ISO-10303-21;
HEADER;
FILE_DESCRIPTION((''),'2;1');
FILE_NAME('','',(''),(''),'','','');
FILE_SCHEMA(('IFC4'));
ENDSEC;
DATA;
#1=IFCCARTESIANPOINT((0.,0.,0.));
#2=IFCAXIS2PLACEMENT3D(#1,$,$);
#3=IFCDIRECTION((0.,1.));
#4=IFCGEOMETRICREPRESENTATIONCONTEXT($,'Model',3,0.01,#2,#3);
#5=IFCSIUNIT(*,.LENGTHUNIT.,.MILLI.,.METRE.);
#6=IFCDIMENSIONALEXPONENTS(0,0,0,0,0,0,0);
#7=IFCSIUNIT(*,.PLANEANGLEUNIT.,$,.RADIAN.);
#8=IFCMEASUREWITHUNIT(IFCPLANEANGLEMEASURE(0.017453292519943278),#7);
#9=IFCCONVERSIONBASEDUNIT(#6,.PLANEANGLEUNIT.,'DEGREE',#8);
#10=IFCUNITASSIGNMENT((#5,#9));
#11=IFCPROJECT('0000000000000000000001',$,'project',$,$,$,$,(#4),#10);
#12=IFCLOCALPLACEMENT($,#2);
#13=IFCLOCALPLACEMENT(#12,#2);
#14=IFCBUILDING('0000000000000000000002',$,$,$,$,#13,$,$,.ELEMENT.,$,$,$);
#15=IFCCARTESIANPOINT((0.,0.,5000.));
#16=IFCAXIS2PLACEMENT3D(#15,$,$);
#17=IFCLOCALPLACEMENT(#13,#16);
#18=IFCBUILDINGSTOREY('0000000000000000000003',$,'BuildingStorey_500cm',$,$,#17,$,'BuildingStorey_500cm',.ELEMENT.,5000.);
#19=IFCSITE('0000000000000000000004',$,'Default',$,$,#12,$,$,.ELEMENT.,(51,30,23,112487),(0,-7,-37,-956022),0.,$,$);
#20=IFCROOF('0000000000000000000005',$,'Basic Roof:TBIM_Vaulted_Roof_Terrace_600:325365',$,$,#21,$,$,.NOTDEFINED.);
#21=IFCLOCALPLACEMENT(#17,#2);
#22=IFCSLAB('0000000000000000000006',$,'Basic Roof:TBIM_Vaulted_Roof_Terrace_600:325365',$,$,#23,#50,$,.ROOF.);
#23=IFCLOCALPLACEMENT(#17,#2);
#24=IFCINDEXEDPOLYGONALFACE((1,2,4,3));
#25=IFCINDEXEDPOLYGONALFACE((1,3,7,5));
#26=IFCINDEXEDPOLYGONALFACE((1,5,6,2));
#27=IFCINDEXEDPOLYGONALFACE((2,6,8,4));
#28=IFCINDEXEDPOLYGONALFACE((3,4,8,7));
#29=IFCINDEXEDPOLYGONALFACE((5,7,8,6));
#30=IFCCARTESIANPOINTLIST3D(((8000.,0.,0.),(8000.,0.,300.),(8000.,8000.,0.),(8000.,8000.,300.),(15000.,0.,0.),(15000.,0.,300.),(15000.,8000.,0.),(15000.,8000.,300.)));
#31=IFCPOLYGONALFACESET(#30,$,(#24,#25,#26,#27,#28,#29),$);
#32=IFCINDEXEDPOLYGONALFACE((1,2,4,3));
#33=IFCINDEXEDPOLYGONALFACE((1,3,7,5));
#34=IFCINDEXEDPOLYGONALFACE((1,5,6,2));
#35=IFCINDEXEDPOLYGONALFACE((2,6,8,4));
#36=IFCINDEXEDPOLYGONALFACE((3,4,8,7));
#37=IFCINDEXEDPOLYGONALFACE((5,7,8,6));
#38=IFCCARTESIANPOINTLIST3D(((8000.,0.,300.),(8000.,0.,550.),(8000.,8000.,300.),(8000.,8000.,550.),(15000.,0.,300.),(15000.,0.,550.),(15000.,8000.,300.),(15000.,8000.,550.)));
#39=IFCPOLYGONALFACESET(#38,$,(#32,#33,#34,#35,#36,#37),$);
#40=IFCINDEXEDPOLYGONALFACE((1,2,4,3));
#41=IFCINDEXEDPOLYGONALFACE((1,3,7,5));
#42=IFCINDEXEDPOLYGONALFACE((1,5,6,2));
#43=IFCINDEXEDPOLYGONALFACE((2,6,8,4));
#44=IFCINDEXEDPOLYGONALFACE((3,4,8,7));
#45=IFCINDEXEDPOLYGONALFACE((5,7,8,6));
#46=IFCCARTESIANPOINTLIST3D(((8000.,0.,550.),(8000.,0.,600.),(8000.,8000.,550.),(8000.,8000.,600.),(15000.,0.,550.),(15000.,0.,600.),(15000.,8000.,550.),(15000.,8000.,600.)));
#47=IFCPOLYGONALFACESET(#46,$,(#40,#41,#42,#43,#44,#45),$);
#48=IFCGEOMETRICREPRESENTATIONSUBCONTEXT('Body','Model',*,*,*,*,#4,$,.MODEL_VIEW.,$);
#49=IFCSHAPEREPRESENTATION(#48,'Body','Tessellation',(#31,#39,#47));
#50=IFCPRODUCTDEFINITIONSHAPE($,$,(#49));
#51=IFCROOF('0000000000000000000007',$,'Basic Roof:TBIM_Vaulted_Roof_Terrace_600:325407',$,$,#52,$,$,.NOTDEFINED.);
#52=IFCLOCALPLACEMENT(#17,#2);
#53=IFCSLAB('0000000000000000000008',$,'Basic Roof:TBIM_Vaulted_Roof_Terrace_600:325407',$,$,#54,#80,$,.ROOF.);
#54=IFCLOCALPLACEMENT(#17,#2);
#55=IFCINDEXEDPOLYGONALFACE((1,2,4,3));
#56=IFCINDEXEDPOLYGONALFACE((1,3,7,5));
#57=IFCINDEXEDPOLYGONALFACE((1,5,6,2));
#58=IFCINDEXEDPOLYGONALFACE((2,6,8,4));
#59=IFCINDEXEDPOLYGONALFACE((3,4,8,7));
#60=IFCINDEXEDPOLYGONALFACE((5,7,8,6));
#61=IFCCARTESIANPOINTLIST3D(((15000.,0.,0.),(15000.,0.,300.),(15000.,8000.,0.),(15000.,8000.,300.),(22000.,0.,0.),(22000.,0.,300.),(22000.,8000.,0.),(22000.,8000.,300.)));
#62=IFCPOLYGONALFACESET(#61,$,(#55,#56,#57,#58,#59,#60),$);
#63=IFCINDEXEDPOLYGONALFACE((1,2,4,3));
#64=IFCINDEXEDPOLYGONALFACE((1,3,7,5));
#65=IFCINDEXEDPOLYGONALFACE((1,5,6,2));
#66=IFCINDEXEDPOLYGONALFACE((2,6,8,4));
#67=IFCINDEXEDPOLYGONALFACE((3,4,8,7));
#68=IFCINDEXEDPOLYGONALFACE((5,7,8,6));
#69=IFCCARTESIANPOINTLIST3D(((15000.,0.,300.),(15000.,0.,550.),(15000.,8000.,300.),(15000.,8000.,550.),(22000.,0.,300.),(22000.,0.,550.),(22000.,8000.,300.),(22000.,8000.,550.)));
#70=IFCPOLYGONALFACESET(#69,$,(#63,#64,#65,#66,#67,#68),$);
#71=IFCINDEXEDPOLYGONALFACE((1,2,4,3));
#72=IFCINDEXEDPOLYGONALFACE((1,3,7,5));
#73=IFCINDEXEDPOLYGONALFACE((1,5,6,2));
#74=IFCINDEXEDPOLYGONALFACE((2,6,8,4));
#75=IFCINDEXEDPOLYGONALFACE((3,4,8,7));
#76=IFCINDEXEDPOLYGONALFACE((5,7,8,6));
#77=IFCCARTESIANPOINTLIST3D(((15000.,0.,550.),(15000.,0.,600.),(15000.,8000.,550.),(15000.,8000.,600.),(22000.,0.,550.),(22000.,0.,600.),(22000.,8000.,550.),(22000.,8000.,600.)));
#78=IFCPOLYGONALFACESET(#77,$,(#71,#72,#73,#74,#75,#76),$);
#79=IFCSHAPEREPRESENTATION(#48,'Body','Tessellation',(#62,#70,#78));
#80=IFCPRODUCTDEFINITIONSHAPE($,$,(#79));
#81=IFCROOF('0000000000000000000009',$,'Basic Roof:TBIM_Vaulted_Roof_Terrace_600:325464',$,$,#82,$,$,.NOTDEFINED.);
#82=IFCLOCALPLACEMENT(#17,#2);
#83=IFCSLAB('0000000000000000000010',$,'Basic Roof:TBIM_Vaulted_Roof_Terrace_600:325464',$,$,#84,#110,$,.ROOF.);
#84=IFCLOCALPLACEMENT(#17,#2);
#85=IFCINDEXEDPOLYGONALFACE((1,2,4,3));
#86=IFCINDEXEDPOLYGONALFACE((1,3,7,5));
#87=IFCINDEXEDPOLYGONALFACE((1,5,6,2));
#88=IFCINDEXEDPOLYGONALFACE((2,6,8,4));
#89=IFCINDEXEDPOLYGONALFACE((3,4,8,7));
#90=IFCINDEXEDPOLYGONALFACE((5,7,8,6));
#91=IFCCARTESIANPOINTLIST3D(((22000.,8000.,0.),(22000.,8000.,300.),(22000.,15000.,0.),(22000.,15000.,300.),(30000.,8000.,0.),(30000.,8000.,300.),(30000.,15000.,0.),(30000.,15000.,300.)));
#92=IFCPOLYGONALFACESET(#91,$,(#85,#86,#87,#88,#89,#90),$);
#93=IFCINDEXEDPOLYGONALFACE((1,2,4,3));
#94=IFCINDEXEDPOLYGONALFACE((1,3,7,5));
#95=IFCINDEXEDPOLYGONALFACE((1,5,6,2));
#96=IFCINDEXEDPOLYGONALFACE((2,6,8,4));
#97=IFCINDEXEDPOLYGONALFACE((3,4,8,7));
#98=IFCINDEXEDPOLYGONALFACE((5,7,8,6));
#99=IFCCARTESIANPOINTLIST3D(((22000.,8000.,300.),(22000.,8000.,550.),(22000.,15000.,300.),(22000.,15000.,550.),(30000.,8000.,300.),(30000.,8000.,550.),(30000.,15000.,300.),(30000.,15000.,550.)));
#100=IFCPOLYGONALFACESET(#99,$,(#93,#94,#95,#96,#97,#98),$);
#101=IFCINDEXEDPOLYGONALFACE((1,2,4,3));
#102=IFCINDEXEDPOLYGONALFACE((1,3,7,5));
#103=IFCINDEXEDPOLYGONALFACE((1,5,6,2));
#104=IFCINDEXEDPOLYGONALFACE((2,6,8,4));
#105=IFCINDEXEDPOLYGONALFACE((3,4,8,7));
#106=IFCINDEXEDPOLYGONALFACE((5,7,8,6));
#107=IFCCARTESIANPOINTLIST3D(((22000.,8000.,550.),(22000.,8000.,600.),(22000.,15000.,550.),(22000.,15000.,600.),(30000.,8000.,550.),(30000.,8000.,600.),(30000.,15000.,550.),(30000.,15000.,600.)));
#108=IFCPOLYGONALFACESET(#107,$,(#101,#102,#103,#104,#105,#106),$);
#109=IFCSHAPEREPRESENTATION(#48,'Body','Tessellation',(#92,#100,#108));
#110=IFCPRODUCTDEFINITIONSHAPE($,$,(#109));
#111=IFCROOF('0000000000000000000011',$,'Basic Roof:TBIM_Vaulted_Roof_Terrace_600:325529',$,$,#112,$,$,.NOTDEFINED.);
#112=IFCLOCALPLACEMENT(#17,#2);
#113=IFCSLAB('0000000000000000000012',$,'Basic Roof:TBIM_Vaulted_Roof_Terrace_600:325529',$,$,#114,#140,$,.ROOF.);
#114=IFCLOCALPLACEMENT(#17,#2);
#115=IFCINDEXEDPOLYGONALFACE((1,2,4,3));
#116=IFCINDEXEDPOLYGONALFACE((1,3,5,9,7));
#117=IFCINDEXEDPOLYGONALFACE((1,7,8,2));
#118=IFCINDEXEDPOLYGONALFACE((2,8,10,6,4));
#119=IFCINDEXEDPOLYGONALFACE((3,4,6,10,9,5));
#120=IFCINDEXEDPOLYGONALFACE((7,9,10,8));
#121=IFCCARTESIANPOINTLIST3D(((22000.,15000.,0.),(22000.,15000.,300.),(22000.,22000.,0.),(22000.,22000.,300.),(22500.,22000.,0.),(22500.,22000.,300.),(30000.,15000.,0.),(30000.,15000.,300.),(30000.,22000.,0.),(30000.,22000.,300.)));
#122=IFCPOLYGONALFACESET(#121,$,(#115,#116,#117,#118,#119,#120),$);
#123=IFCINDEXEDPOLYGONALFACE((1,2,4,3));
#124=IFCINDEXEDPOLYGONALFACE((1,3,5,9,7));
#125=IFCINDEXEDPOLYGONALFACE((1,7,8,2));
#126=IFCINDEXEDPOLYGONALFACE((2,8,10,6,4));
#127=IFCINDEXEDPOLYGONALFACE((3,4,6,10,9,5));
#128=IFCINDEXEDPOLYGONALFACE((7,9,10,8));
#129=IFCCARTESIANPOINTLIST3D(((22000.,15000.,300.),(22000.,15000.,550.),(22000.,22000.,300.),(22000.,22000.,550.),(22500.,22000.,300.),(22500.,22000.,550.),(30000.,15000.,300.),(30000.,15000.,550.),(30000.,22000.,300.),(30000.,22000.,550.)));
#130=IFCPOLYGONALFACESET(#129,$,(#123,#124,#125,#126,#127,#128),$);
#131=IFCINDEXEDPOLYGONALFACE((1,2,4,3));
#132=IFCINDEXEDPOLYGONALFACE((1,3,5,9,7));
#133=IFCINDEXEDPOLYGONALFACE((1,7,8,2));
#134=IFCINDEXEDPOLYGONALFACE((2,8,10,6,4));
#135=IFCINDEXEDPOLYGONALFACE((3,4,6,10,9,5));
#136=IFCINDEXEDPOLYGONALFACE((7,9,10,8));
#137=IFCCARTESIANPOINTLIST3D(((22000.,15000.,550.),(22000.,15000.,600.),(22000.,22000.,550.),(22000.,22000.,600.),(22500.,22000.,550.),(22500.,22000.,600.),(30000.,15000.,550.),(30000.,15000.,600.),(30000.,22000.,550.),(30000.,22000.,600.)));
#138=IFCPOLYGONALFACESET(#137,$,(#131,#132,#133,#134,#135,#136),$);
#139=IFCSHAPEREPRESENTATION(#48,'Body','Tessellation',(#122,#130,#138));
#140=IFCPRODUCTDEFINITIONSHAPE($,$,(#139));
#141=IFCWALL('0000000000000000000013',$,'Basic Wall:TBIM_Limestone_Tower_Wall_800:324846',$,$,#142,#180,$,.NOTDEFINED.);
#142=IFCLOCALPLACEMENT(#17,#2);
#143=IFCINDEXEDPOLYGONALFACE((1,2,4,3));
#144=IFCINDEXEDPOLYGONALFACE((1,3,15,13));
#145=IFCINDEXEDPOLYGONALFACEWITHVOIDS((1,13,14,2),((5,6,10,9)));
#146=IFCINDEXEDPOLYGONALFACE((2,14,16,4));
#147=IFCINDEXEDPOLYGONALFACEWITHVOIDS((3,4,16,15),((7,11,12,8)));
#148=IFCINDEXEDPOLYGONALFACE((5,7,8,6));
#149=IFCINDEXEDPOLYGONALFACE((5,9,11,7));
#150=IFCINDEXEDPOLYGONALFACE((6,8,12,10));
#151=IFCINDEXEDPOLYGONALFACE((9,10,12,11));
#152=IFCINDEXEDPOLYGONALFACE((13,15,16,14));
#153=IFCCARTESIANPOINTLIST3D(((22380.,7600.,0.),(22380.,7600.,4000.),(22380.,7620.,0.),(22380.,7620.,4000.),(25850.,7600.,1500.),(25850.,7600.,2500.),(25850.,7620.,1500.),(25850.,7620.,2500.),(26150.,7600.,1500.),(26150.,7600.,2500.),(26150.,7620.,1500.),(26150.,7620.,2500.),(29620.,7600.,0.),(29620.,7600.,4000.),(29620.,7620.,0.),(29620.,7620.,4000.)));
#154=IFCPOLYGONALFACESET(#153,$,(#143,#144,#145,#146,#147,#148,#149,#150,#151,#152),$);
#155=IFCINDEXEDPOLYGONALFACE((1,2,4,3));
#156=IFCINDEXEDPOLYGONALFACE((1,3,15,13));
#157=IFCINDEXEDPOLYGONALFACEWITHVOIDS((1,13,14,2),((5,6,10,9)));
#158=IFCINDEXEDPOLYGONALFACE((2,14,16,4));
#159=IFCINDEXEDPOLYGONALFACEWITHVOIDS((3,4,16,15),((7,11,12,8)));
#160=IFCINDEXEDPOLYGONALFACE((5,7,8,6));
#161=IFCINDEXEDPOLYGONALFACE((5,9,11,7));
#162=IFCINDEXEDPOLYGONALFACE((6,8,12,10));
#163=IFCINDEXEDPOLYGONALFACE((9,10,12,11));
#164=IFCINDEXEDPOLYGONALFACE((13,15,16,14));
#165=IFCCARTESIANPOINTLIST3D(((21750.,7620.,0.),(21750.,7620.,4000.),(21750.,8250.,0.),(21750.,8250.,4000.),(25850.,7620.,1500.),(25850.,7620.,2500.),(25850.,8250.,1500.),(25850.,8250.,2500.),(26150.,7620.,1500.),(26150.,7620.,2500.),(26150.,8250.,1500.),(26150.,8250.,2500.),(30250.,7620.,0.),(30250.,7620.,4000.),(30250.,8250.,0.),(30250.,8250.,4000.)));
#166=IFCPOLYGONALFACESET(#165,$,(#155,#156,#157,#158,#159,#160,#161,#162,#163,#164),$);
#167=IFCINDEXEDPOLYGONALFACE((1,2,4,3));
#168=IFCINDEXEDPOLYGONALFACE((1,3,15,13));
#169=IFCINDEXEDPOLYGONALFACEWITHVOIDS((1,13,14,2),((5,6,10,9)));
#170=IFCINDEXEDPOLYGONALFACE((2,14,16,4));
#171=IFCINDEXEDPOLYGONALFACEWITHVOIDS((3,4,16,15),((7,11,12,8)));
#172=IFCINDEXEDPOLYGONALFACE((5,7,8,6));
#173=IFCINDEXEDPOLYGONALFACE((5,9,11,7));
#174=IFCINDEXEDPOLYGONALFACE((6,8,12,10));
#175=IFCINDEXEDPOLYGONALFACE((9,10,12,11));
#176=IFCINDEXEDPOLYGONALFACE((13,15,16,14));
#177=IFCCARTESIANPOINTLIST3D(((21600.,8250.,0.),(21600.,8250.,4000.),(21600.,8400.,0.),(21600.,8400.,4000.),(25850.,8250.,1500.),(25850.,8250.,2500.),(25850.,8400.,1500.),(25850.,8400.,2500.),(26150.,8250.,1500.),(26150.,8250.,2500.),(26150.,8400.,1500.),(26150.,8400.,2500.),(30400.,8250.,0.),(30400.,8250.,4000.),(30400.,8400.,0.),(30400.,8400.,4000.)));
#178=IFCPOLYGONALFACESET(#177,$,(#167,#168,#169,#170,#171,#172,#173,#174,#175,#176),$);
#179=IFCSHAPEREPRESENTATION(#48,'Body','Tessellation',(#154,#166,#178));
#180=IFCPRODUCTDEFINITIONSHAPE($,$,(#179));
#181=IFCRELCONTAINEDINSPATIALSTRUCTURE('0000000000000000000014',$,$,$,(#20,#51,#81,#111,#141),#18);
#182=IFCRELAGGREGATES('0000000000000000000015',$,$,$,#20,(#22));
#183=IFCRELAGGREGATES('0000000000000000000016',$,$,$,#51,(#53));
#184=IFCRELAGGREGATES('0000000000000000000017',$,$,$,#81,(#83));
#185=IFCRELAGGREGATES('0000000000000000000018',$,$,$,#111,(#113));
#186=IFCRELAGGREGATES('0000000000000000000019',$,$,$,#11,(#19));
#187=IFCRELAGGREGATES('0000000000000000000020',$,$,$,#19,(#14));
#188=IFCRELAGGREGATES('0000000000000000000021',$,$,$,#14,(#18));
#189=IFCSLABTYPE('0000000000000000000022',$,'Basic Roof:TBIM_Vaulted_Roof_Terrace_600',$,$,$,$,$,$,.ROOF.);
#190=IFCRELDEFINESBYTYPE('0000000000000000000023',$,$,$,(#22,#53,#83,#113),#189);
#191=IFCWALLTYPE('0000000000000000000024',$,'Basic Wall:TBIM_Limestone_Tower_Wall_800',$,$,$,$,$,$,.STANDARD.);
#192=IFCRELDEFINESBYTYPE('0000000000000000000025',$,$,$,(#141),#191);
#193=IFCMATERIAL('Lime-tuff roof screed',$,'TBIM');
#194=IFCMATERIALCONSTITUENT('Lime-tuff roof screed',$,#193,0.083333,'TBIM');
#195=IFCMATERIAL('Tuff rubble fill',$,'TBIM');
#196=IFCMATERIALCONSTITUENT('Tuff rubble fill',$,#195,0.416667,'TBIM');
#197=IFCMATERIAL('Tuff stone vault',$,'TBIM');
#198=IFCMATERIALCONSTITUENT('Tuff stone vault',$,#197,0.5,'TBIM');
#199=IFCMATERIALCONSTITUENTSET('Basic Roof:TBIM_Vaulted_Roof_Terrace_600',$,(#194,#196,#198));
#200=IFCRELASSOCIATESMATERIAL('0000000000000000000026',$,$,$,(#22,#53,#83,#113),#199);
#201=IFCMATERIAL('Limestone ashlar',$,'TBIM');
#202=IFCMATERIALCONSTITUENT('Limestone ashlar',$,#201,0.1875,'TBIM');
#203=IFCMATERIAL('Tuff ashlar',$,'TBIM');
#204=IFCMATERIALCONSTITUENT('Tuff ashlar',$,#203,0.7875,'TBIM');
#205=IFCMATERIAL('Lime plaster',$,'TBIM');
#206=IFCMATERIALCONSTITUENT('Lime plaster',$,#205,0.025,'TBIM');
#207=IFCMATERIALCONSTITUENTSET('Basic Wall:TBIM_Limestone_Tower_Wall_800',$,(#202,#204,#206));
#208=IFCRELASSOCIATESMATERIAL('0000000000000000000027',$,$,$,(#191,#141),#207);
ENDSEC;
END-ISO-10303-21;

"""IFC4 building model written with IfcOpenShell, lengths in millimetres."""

from ifc_helpers import new_model, entity, si_unit, converted_unit, direction, frame, origin, place, context, subcontext, project, spatial, indexed_curve, outline, extrude, material, constituent, constituent_set, type_object, element, aggregate, save


model = new_model("IFC4")

# Units and contexts
model_context = context("Model", 3, precision=0.01, world=origin(), true_north=direction((0.0, 1.0)))
body_context = subcontext(model_context, "Body", "Model", "MODEL_VIEW")
ifc_project = project(units=[si_unit("LENGTHUNIT", "METRE", prefix="MILLI"), converted_unit("PLANEANGLEUNIT", "DEGREE", entity("IfcPlaneAngleMeasure", 0.017453292519943278), si_unit("PLANEANGLEUNIT", "RADIAN"), dimensions=[0, 0, 0, 0, 0, 0, 0])], contexts=[model_context])

# Site, building, storey
site_placement = place(None, origin())
site = spatial("IfcSite", under=ifc_project, at=site_placement, Name="Default", CompositionType="ELEMENT", RefLatitude=(51, 30, 23, 112487), RefLongitude=(0, -7, -37, -956022), RefElevation=0.0)
building_placement = place(site_placement, origin())
building = spatial("IfcBuilding", under=site, at=building_placement, CompositionType="ELEMENT")
storey_placement = place(building_placement, frame((0.0, 0.0, 5000.0)))
storey = spatial("IfcBuildingStorey", under=building, at=storey_placement, Name="BuildingStorey_500cm", LongName="BuildingStorey_500cm", CompositionType="ELEMENT", Elevation=5000.0)

# Roofs, slabs
roof_1_placement = place(storey_placement, frame((8000.0, 0.0, 0.0)))
roof_1 = element("IfcRoof", 1, at=roof_1_placement, inside=storey, Name="Basic Roof:TBIM_Vaulted_Roof_Terrace_600:325365", PredefinedType="NOTDEFINED")
ifc_material_1 = material(Name="Lime-tuff roof screed", Category="TBIM")
ifc_constituent_1 = constituent(ifc_material_1, Name="Lime-tuff roof screed", Category="TBIM", fraction=0.083333)
ifc_material_2 = material(Name="Tuff rubble fill", Category="TBIM")
ifc_constituent_2 = constituent(ifc_material_2, Name="Tuff rubble fill", Category="TBIM", fraction=0.416667)
ifc_material_3 = material(Name="Tuff stone vault", Category="TBIM")
ifc_constituent_3 = constituent(ifc_material_3, Name="Tuff stone vault", Category="TBIM", fraction=0.5)
ifc_constituent_set_1 = constituent_set(constituents=[ifc_constituent_1, ifc_constituent_2, ifc_constituent_3], Name="Basic Roof:TBIM_Vaulted_Roof_Terrace_600")
slab_type = type_object("IfcSlabType", Name="Basic Roof:TBIM_Vaulted_Roof_Terrace_600", PredefinedType="ROOF")
slab_1_placement = place(roof_1_placement, origin())
slab_1 = element("IfcSlab", 2, at=slab_1_placement, type_object=slab_type, material=ifc_constituent_set_1, Name="Basic Roof:TBIM_Vaulted_Roof_Terrace_600:325365", PredefinedType="ROOF", context=body_context, shape_type="SweptSolid", body=[
    extrude(outline(indexed_curve([(-3500.0, 4000.0), (-3500.0, -4000.0), (3500.0, -4000.0), (3500.0, 4000.0), (-3500.0, 4000.0)], self_intersect=False)), frame((3500.0, 4000.0, 0.0)), (0.0, 0.0, 1.0), 300.0),
    extrude(outline(indexed_curve([(-3500.0, 4000.0), (-3500.0, -4000.0), (3500.0, -4000.0), (3500.0, 4000.0), (-3500.0, 4000.0)], self_intersect=False)), frame((3500.0, 4000.0, 300.0)), (0.0, 0.0, 1.0), 250.0),
    extrude(outline(indexed_curve([(-3500.0, 4000.0), (-3500.0, -4000.0), (3500.0, -4000.0), (3500.0, 4000.0), (-3500.0, 4000.0)], self_intersect=False)), frame((3500.0, 4000.0, 550.0)), (0.0, 0.0, 1.0), 50.0),
])
aggregate(roof_1, [slab_1])
roof_2_placement = place(storey_placement, frame((15000.0, 0.0, 0.0)))
roof_2 = element("IfcRoof", 3, at=roof_2_placement, inside=storey, Name="Basic Roof:TBIM_Vaulted_Roof_Terrace_600:325407", PredefinedType="NOTDEFINED")
slab_2_placement = place(roof_2_placement, origin())
slab_2 = element("IfcSlab", 4, at=slab_2_placement, type_object=slab_type, material=ifc_constituent_set_1, Name="Basic Roof:TBIM_Vaulted_Roof_Terrace_600:325407", PredefinedType="ROOF", context=body_context, shape_type="SweptSolid", body=[
    extrude(outline(indexed_curve([(-3500.0, 4000.0), (-3500.0, -4000.0), (3500.0, -4000.0), (3500.0, 4000.0), (-3500.0, 4000.0)], self_intersect=False)), frame((3500.0, 4000.0, 0.0)), (0.0, 0.0, 1.0), 300.0),
    extrude(outline(indexed_curve([(-3500.0, 4000.0), (-3500.0, -4000.0), (3500.0, -4000.0), (3500.0, 4000.0), (-3500.0, 4000.0)], self_intersect=False)), frame((3500.0, 4000.0, 300.0)), (0.0, 0.0, 1.0), 250.0),
    extrude(outline(indexed_curve([(-3500.0, 4000.0), (-3500.0, -4000.0), (3500.0, -4000.0), (3500.0, 4000.0), (-3500.0, 4000.0)], self_intersect=False)), frame((3500.0, 4000.0, 550.0)), (0.0, 0.0, 1.0), 50.0),
])
aggregate(roof_2, [slab_2])
roof_3_placement = place(storey_placement, frame((22000.0, 8000.0, 0.0)))
roof_3 = element("IfcRoof", 5, at=roof_3_placement, inside=storey, Name="Basic Roof:TBIM_Vaulted_Roof_Terrace_600:325464", PredefinedType="NOTDEFINED")
slab_3_placement = place(roof_3_placement, origin())
slab_3 = element("IfcSlab", 6, at=slab_3_placement, type_object=slab_type, material=ifc_constituent_set_1, Name="Basic Roof:TBIM_Vaulted_Roof_Terrace_600:325464", PredefinedType="ROOF", context=body_context, shape_type="SweptSolid", body=[
    extrude(outline(indexed_curve([(-4000.0, 3500.0), (-4000.0, -3500.0), (4000.0, -3500.0), (4000.0, 3500.0), (-4000.0, 3500.0)], self_intersect=False)), frame((4000.0, 3500.0, 0.0)), (0.0, 0.0, 1.0), 300.0),
    extrude(outline(indexed_curve([(-4000.0, 3500.0), (-4000.0, -3500.0), (4000.0, -3500.0), (4000.0, 3500.0), (-4000.0, 3500.0)], self_intersect=False)), frame((4000.0, 3500.0, 300.0)), (0.0, 0.0, 1.0), 250.0),
    extrude(outline(indexed_curve([(-4000.0, 3500.0), (-4000.0, -3500.0), (4000.0, -3500.0), (4000.0, 3500.0), (-4000.0, 3500.0)], self_intersect=False)), frame((4000.0, 3500.0, 550.0)), (0.0, 0.0, 1.0), 50.0),
])
aggregate(roof_3, [slab_3])
roof_4_placement = place(storey_placement, frame((22000.0, 15000.0, 0.0)))
roof_4 = element("IfcRoof", 7, at=roof_4_placement, inside=storey, Name="Basic Roof:TBIM_Vaulted_Roof_Terrace_600:325529", PredefinedType="NOTDEFINED")
slab_4_placement = place(roof_4_placement, origin())
slab_4 = element("IfcSlab", 8, at=slab_4_placement, type_object=slab_type, material=ifc_constituent_set_1, Name="Basic Roof:TBIM_Vaulted_Roof_Terrace_600:325529", PredefinedType="ROOF", context=body_context, shape_type="SweptSolid", body=[
    extrude(outline(indexed_curve([(4000.0, 3500.0), (-3500.0, 3500.0), (-4000.0, 3500.0), (-4000.0, -3500.0), (4000.0, -3500.0), (4000.0, 3500.0)], self_intersect=False)), frame((4000.0, 3500.0, 0.0)), (0.0, 0.0, 1.0), 300.0),
    extrude(outline(indexed_curve([(4000.0, 3500.0), (-3500.0, 3500.0), (-4000.0, 3500.0), (-4000.0, -3500.0), (4000.0, -3500.0), (4000.0, 3500.0)], self_intersect=False)), frame((4000.0, 3500.0, 300.0)), (0.0, 0.0, 1.0), 250.0),
    extrude(outline(indexed_curve([(4000.0, 3500.0), (-3500.0, 3500.0), (-4000.0, 3500.0), (-4000.0, -3500.0), (4000.0, -3500.0), (4000.0, 3500.0)], self_intersect=False)), frame((4000.0, 3500.0, 550.0)), (0.0, 0.0, 1.0), 50.0),
])
aggregate(roof_4, [slab_4])

# Shared definitions
ifc_material_4 = material(Name="Tuff ashlar", Category="TBIM")
ifc_material_5 = material(Name="Lime plaster", Category="TBIM")

# Wall, opening
ifc_material_6 = material(Name="Limestone ashlar", Category="TBIM")
ifc_constituent_4 = constituent(ifc_material_6, Name="Limestone ashlar", Category="TBIM", fraction=0.1875)
ifc_constituent_5 = constituent(ifc_material_4, Name="Tuff ashlar", Category="TBIM", fraction=0.7875)
ifc_constituent_6 = constituent(ifc_material_5, Name="Lime plaster", Category="TBIM", fraction=0.025)
ifc_constituent_set_2 = constituent_set(constituents=[ifc_constituent_4, ifc_constituent_5, ifc_constituent_6], Name="Basic Wall:TBIM_Limestone_Tower_Wall_800")
wall_type_1 = type_object("IfcWallType", Name="Basic Wall:TBIM_Limestone_Tower_Wall_800", PredefinedType="STANDARD", material=ifc_constituent_set_2)
wall_1_placement = place(storey_placement, frame((21600.0, 8000.0, 0.0)))
wall_1 = element("IfcWall", 9, at=wall_1_placement, inside=storey, type_object=wall_type_1, material=ifc_constituent_set_2, Name="Basic Wall:TBIM_Limestone_Tower_Wall_800:324846", PredefinedType="NOTDEFINED", context=body_context, shape_type="SweptSolid", body=[
    extrude(outline(indexed_curve([(-2000.0, -3620.0), (2000.0, -3620.0), (2000.0, -3600.0), (2000.0, 3600.0), (2000.0, 3620.0), (-2000.0, 3620.0), (-2000.0, 3600.0), (-2000.0, -3600.0), (-2000.0, -3620.0)], self_intersect=False), holes=[indexed_curve([(500.0, -150.0), (-500.0, -150.0), (-500.0, 150.0), (500.0, 150.0), (500.0, -150.0)], self_intersect=False)]), frame((4400.0, -400.0, 2000.0), z_axis=(0.0, 1.0, 0.0), x_axis=(0.0, 0.0, 1.0)), (0.0, 0.0, 1.0), 20.0),
    extrude(outline(indexed_curve([(-2000.0, -4250.0), (2000.0, -4250.0), (2000.0, 4250.0), (-2000.0, 4250.0), (-2000.0, -4250.0)], self_intersect=False), holes=[indexed_curve([(-500.0, -150.0), (-500.0, 150.0), (500.0, 150.0), (500.0, -150.0), (-500.0, -150.0)], self_intersect=False)]), frame((4400.0, -380.0, 2000.0), z_axis=(0.0, 1.0, 0.0), x_axis=(0.0, 0.0, 1.0)), (0.0, 0.0, 1.0), 630.0),
    extrude(outline(indexed_curve([(-2000.0, -4400.0), (2000.0, -4400.0), (2000.0, 4400.0), (-2000.0, 4400.0), (-2000.0, -4400.0)], self_intersect=False), holes=[indexed_curve([(-500.0, -150.0), (-500.0, 150.0), (500.0, 150.0), (500.0, -150.0), (-500.0, -150.0)], self_intersect=False)]), frame((4400.0, 250.0, 2000.0), z_axis=(0.0, 1.0, 0.0), x_axis=(0.0, 0.0, 1.0)), (0.0, 0.0, 1.0), 150.0),
])
opening_1_placement = place(wall_1_placement, frame((4250.0, -400.0, 1500.0)))
element("IfcOpeningElement", 10, at=opening_1_placement, cuts=wall_1, PredefinedType="OPENING", context=body_context, shape_type="SweptSolid", body=[
    extrude(outline(indexed_curve([(1000.0, 0.0), (1000.0, 300.0), (0.0, 300.0), (0.0, 0.0), (1000.0, 0.0)], self_intersect=False)), frame((0.0, 0.0, 0.0), z_axis=(0.0, 1.0, 0.0), x_axis=(0.0, 0.0, 1.0)), (0.0, 0.0, 1.0), 800.0),
])

save(model, "model.ifc")
